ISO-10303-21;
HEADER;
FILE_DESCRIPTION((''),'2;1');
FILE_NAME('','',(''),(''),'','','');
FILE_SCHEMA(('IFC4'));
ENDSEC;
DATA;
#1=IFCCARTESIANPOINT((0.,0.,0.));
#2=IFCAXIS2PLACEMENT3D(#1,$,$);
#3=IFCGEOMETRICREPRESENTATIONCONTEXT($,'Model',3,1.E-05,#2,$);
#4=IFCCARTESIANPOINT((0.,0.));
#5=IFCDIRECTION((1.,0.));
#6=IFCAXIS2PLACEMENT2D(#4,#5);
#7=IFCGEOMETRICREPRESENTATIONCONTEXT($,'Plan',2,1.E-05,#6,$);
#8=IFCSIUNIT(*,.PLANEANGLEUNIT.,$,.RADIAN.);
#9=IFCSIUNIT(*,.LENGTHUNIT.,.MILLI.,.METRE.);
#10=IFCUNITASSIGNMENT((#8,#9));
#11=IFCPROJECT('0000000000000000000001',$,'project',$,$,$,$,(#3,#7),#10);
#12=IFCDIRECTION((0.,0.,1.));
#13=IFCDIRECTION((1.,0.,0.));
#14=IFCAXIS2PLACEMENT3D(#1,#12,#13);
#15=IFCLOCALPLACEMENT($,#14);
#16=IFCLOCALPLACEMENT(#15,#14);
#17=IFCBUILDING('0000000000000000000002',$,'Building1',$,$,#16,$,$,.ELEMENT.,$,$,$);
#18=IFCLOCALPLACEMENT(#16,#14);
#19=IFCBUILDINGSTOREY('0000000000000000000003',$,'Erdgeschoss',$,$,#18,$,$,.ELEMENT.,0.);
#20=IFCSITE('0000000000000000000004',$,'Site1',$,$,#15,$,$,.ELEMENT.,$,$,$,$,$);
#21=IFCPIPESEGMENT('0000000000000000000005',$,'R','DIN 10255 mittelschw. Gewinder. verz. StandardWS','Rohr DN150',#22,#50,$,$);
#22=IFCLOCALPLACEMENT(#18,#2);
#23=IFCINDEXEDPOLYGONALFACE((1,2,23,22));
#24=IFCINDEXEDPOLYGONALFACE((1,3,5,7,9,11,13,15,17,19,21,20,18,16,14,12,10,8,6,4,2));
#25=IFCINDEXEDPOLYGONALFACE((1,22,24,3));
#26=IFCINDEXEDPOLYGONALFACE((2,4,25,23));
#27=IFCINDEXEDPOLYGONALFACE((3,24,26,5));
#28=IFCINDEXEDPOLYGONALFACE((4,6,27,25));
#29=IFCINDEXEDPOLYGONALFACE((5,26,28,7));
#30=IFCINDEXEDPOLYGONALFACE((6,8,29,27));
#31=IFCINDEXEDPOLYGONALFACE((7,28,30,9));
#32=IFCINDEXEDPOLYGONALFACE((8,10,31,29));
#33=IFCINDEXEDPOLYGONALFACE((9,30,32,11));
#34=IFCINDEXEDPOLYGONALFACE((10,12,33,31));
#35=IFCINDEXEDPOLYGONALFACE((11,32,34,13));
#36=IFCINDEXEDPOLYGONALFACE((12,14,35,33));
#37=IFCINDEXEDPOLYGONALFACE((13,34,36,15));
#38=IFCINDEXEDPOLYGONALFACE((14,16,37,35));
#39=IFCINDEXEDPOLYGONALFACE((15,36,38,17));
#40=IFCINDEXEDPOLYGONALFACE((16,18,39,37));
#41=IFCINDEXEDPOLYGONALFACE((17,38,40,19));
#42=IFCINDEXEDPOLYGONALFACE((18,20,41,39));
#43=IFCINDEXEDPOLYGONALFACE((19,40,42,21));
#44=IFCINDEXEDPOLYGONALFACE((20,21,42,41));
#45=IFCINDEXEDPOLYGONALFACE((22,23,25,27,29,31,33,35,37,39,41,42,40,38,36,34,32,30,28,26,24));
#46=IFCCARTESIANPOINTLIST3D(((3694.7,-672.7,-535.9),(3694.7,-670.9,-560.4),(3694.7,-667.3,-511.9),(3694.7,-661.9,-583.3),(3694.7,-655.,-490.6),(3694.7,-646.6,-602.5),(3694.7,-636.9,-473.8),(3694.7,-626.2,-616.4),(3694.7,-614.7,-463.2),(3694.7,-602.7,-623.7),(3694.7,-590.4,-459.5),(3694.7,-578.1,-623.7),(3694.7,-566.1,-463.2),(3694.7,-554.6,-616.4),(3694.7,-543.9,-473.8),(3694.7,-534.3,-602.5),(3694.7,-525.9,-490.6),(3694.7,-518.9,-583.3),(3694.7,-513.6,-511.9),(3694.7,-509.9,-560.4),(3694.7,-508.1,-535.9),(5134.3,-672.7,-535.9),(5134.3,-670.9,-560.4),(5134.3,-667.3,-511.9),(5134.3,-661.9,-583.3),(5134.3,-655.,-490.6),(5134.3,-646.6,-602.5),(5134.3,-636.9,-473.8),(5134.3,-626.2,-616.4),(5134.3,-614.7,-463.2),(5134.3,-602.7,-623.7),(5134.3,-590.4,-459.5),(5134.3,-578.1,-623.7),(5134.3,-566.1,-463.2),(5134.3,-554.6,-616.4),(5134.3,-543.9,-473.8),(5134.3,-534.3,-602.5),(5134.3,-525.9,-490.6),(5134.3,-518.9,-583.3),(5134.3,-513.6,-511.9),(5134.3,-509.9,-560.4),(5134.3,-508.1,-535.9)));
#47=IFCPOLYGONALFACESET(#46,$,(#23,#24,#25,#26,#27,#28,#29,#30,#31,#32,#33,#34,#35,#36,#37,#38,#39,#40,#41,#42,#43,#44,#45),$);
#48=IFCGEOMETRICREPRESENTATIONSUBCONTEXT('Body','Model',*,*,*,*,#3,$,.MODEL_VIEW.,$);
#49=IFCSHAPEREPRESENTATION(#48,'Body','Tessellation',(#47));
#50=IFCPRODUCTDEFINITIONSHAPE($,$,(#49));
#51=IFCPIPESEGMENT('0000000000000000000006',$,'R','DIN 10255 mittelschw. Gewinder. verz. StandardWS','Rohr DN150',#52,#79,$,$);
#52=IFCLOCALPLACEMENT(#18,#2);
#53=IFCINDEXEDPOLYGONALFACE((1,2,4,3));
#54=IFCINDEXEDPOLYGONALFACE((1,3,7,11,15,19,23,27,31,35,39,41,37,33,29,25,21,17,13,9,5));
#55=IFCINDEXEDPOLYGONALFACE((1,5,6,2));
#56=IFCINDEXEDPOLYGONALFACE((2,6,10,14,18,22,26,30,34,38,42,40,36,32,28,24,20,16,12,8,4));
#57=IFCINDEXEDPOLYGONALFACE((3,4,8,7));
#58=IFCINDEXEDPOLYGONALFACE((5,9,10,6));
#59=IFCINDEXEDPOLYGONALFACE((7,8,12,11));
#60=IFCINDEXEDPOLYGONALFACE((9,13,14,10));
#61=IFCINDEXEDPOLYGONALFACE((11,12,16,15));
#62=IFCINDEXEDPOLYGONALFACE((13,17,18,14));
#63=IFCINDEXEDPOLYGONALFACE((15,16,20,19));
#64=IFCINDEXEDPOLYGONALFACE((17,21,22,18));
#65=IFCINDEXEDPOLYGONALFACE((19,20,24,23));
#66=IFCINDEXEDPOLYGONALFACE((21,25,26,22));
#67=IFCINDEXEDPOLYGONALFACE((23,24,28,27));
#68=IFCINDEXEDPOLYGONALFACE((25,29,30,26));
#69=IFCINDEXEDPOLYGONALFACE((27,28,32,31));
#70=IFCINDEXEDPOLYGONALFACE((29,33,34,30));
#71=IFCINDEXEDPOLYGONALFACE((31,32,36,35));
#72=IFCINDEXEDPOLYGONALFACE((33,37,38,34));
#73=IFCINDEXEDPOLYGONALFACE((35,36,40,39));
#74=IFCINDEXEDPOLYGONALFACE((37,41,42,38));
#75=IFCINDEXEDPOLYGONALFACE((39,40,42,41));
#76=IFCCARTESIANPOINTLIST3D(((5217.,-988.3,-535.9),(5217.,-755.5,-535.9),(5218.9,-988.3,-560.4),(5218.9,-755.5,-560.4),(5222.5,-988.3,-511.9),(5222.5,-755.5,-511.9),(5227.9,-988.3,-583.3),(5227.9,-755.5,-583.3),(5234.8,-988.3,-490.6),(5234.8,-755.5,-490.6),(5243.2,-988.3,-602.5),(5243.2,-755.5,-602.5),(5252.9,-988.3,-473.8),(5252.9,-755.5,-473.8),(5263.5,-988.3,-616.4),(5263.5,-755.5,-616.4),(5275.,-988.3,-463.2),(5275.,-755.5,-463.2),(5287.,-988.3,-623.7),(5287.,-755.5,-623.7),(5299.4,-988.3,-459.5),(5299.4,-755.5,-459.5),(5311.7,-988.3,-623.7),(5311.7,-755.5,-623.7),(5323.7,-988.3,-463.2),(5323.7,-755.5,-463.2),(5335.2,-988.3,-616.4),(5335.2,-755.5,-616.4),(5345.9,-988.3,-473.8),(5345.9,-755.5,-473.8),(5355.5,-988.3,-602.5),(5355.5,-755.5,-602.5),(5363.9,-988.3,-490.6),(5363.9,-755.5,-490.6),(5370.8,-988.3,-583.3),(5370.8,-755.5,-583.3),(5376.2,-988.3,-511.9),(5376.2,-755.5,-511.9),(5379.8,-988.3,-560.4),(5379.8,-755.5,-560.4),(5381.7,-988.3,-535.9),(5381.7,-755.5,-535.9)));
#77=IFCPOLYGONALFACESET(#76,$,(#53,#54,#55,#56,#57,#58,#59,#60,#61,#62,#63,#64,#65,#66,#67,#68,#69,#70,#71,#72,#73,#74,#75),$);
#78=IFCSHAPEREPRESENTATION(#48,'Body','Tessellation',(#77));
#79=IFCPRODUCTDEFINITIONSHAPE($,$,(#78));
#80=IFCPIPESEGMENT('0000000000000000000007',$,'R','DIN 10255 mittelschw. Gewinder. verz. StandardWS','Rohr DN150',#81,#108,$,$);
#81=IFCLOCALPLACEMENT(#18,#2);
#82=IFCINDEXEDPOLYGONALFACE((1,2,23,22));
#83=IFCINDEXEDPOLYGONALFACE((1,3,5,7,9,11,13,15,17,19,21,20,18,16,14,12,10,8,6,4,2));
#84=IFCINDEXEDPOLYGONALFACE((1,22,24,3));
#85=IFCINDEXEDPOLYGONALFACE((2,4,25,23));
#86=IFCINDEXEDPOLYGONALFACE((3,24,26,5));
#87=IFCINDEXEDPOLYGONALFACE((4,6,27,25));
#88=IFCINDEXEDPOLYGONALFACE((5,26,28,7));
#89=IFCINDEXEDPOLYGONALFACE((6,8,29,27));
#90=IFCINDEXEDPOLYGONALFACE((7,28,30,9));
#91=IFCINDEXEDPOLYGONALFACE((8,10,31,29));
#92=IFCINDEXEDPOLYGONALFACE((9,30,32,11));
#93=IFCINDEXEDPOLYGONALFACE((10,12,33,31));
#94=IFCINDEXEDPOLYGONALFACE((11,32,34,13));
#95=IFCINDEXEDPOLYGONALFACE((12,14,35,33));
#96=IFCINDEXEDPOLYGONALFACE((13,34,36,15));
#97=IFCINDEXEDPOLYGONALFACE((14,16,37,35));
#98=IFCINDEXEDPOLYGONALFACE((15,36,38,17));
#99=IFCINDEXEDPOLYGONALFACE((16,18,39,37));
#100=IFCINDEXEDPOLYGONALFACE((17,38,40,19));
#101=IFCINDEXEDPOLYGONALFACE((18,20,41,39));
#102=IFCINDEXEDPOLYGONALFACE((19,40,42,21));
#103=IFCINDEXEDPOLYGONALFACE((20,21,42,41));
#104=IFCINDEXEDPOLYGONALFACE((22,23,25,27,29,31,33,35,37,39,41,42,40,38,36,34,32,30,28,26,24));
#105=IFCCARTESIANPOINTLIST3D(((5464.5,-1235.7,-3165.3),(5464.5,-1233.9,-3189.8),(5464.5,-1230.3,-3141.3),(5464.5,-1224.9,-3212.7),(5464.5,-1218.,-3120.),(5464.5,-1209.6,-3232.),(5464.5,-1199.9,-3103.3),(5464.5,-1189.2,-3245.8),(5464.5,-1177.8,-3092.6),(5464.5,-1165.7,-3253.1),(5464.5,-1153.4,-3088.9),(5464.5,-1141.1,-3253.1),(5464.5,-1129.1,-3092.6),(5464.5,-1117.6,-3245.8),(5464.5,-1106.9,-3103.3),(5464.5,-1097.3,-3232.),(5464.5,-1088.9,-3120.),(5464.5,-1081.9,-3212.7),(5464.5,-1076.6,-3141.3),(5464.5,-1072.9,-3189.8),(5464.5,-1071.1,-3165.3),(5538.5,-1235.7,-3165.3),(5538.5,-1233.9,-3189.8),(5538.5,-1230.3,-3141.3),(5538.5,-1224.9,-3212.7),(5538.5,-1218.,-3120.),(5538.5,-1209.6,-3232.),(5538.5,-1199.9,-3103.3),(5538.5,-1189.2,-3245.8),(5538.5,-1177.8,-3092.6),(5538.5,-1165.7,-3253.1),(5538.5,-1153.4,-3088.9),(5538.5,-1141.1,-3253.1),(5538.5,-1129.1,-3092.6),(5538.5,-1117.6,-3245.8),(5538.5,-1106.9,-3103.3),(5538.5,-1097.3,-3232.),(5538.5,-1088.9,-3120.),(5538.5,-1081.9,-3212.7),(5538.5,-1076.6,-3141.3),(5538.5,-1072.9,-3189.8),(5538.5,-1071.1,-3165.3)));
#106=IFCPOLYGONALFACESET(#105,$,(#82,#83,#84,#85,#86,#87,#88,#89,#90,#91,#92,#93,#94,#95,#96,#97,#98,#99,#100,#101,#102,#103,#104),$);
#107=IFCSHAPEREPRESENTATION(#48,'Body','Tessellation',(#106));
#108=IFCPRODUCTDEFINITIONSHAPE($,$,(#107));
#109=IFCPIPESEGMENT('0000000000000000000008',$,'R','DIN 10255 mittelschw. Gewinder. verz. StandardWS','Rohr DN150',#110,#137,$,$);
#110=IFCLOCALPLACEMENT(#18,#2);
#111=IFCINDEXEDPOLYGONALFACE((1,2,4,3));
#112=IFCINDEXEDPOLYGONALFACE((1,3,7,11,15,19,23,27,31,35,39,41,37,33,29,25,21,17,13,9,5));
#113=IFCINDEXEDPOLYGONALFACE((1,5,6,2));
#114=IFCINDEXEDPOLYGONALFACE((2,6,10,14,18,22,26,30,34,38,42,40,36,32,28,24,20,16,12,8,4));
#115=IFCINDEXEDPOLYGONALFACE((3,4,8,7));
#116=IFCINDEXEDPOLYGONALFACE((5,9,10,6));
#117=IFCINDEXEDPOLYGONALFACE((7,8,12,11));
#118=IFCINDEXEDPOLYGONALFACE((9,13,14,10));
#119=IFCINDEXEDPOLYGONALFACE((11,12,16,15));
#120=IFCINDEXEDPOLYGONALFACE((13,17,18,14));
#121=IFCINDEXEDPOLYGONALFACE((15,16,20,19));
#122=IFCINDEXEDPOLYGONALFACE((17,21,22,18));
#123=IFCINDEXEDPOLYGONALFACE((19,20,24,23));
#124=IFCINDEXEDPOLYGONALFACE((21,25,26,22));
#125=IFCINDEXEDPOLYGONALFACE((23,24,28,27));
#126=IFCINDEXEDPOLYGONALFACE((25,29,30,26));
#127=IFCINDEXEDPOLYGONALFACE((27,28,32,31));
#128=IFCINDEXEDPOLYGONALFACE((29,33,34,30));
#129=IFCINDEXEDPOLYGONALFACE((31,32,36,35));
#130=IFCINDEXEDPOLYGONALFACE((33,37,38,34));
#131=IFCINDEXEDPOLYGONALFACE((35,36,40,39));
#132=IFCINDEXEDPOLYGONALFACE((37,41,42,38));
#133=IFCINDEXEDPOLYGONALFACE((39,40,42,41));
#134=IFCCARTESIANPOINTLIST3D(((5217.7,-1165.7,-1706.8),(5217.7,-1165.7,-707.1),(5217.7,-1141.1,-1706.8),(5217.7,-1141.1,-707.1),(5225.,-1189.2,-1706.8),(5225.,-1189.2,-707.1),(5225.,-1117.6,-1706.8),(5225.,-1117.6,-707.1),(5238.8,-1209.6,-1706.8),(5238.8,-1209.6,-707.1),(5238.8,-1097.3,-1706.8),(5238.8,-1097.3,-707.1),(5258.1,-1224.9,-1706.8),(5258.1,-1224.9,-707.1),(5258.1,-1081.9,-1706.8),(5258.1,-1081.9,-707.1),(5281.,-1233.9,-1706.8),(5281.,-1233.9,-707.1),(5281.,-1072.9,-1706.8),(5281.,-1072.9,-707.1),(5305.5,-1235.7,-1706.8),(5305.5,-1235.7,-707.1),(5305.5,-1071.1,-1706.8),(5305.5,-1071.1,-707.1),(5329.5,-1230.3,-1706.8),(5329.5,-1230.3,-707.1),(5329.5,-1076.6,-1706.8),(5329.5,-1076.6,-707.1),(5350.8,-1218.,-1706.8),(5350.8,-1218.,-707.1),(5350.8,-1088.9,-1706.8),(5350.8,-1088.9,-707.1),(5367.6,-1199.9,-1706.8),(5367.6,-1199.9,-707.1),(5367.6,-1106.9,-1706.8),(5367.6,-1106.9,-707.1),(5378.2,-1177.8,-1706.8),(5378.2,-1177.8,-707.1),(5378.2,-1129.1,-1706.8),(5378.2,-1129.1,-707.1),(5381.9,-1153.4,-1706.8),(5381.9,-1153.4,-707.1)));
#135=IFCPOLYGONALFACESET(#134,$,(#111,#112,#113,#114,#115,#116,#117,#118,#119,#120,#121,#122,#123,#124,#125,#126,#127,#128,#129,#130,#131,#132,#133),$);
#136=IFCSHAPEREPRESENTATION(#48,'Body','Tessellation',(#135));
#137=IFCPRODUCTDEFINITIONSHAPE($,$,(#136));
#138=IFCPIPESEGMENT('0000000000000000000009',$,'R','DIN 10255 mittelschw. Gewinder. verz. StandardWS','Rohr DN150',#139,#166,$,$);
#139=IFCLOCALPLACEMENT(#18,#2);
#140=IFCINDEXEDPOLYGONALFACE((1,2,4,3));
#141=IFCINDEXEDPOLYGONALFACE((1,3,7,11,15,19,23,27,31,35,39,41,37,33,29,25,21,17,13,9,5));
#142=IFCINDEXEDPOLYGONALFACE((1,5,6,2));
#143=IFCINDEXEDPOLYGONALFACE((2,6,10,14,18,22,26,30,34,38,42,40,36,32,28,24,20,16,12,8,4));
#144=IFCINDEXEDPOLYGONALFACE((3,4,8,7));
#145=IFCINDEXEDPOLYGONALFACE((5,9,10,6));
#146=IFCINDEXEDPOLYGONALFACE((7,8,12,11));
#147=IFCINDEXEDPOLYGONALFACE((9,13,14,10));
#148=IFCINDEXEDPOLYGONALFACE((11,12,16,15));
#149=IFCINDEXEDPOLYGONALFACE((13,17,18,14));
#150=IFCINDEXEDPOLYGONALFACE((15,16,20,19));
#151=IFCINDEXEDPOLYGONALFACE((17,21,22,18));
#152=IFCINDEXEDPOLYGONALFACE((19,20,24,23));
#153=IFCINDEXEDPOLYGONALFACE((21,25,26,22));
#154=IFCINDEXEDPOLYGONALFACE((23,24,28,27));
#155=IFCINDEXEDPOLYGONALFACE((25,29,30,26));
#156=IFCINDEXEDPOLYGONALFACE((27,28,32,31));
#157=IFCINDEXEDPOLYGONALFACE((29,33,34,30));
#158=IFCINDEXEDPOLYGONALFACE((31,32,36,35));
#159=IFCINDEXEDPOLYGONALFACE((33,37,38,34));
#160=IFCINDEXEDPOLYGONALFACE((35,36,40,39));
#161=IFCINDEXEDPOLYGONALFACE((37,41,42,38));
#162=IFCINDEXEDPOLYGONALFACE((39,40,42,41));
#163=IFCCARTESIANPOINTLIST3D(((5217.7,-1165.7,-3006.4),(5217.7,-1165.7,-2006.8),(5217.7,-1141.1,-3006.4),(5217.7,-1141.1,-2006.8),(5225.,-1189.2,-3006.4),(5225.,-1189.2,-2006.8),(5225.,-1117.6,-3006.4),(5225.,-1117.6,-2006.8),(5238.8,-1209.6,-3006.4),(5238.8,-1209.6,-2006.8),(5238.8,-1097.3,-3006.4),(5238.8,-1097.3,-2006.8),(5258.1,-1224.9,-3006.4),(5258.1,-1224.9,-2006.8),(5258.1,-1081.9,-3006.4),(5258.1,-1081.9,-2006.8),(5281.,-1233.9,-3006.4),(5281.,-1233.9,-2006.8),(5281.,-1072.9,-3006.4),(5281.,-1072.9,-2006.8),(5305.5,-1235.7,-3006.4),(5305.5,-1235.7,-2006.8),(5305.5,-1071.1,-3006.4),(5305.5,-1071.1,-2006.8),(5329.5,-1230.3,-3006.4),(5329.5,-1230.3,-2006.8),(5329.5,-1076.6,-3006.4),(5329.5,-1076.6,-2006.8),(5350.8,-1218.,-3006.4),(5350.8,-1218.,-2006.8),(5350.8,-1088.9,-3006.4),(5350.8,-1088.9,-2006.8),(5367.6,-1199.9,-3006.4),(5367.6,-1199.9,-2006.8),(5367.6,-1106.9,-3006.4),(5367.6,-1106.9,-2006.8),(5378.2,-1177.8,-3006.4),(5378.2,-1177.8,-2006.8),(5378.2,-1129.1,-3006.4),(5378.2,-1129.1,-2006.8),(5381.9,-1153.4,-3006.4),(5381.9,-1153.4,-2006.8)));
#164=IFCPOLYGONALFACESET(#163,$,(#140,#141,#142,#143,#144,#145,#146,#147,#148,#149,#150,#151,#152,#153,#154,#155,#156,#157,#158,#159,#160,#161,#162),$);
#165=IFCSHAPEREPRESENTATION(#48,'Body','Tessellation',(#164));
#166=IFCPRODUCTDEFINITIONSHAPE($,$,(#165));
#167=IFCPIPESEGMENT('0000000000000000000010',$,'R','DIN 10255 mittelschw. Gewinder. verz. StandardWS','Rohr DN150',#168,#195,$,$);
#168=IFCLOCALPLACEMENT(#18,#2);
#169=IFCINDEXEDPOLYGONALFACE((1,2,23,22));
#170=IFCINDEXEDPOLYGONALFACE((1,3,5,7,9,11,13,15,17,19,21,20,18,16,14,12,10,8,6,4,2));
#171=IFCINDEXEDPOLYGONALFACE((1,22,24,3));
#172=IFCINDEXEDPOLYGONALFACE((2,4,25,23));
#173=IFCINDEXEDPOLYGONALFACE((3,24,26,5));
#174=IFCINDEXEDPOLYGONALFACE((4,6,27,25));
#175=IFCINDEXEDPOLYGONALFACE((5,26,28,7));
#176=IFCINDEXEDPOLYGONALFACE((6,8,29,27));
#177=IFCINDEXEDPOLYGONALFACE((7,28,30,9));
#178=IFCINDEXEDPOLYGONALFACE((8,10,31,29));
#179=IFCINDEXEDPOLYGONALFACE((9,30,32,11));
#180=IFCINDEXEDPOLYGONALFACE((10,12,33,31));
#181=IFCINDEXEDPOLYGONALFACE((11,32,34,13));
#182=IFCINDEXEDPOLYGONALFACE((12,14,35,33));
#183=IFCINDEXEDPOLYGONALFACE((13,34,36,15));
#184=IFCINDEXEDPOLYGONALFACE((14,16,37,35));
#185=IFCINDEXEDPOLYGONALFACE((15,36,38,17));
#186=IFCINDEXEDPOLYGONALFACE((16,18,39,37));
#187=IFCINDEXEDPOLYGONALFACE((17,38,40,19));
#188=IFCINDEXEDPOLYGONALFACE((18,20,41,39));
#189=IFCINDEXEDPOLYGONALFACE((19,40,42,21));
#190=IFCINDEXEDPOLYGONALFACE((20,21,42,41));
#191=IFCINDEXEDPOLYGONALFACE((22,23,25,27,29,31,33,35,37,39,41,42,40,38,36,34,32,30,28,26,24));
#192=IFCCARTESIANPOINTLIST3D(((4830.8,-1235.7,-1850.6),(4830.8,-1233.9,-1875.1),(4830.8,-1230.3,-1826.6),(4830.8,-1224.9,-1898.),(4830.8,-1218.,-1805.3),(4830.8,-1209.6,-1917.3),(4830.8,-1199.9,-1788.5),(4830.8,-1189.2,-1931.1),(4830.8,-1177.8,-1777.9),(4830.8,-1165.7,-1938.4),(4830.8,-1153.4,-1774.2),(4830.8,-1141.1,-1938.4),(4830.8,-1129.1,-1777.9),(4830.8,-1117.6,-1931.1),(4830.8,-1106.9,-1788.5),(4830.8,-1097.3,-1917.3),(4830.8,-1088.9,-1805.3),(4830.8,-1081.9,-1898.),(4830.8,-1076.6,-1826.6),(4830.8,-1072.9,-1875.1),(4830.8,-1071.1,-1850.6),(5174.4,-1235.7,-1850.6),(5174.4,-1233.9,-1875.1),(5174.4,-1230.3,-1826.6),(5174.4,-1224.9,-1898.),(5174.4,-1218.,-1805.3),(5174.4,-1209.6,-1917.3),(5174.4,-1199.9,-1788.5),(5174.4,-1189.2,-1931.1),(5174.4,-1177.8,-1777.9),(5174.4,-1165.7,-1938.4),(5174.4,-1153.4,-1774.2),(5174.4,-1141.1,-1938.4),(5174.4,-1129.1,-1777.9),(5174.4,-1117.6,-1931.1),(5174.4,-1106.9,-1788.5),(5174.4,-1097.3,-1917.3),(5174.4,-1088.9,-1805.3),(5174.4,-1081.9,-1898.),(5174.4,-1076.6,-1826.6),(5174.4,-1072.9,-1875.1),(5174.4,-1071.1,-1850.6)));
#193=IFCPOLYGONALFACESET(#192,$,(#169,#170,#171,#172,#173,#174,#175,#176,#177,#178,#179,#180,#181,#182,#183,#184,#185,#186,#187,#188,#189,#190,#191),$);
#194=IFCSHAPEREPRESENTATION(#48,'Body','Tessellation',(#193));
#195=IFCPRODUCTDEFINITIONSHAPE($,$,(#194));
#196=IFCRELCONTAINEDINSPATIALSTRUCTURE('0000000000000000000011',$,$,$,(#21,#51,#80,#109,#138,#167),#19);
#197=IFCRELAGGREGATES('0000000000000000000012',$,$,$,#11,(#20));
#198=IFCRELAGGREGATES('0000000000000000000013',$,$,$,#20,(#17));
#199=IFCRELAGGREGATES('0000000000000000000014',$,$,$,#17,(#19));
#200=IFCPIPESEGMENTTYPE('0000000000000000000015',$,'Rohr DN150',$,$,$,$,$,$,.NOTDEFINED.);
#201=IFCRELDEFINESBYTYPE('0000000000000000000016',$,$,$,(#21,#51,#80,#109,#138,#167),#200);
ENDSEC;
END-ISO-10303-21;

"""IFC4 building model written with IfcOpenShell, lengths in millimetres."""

from ifc_helpers import new_model, si_unit, frame, origin, origin_with_axes, origin_2d_with_axis, place, context, subcontext, project, spatial, circle, extrude, type_object, element, save


model = new_model("IFC4")

# Units and contexts
model_context = context("Model", 3, precision=1e-05, world=origin())
plan_context = context("Plan", 2, precision=1e-05, world=origin_2d_with_axis())
body_context = subcontext(model_context, "Body", "Model", "MODEL_VIEW")
ifc_project = project(units=[si_unit("PLANEANGLEUNIT", "RADIAN"), si_unit("LENGTHUNIT", "METRE", prefix="MILLI")], contexts=[model_context, plan_context])

# Site, building, storey
site_placement = place(None, origin_with_axes())
site = spatial("IfcSite", under=ifc_project, at=site_placement, Name="Site1", CompositionType="ELEMENT")
building_placement = place(site_placement, origin_with_axes())
building = spatial("IfcBuilding", under=site, at=building_placement, Name="Building1", CompositionType="ELEMENT")
storey_placement = place(building_placement, origin_with_axes())
storey = spatial("IfcBuildingStorey", under=building, at=storey_placement, Name="Erdgeschoss", CompositionType="ELEMENT", Elevation=0.0)

# Pipe segments
pipe_segment_type_1 = type_object("IfcPipeSegmentType", Name="Rohr DN150", PredefinedType="NOTDEFINED")
pipe_segment_1_placement = place(storey_placement, frame((4414.5, -590.3, -542.0), z_axis=(0.0, 0.0, 1.0), x_axis=(1.0, 0.0, 0.0)))
element("IfcPipeSegment", 1, at=pipe_segment_1_placement, inside=storey, type_object=pipe_segment_type_1, Name="R", Description="DIN 10255 mittelschw. Gewinder. verz. StandardWS", ObjectType="Rohr DN150", context=body_context, shape_type="SolidModel", body=[
    extrude(circle(Radius=82.5, at=origin_2d_with_axis()), frame((-719.8, -0.2, 0.0), z_axis=(1.0, 0.0, 0.0), x_axis=(0.0, 0.0, 1.0)), (0.0, 0.0, 1.0), 1439.6),
])
pipe_segment_2_placement = place(storey_placement, frame((5299.5, -871.9, -542.0), z_axis=(0.0, 0.0, 1.0), x_axis=(1.0, 0.0, 0.0)))
element("IfcPipeSegment", 2, at=pipe_segment_2_placement, inside=storey, type_object=pipe_segment_type_1, Name="R", Description="DIN 10255 mittelschw. Gewinder. verz. StandardWS", ObjectType="Rohr DN150", context=body_context, shape_type="SolidModel", body=[
    extrude(circle(Radius=82.5, at=origin_2d_with_axis()), frame((-0.2, 116.4, 0.0), z_axis=(0.0, -1.0, 0.0), x_axis=(0.0, 0.0, 1.0)), (0.0, 0.0, 1.0), 232.8),
])
pipe_segment_3_placement = place(storey_placement, frame((5501.5, -1153.6, -3171.5), z_axis=(0.0, 0.0, 1.0), x_axis=(1.0, 0.0, 0.0)))
element("IfcPipeSegment", 3, at=pipe_segment_3_placement, inside=storey, type_object=pipe_segment_type_1, Name="R", Description="DIN 10255 mittelschw. Gewinder. verz. StandardWS", ObjectType="Rohr DN150", context=body_context, shape_type="SolidModel", body=[
    extrude(circle(Radius=82.5, at=origin_2d_with_axis()), frame((37.0, 0.1, 0.0), z_axis=(-1.0, 0.0, 0.0), x_axis=(0.0, 0.0, 1.0)), (0.0, 0.0, 1.0), 74.0),
])
for number, where, z_axis, x_axis, name in (
    (4, (5299.4, -1153.3, -1206.9), (0.0, 0.0, 1.0), (1.0, 0.0, 0.0), "R"),
    (5, (5299.4, -1153.3, -2506.6), (0.0, 0.0, 1.0), (1.0, 0.0, 0.0), "R"),
):
    element("IfcPipeSegment", number, at=place(storey_placement, frame(where, z_axis=z_axis, x_axis=x_axis)), inside=storey, type_object=pipe_segment_type_1, Name=name, Description="DIN 10255 mittelschw. Gewinder. verz. StandardWS", ObjectType="Rohr DN150", context=body_context, shape_type="SolidModel", body=[
        extrude(circle(Radius=82.5, at=origin_2d_with_axis()), frame((0.0, -0.1, 499.8), z_axis=(0.0, 0.0, -1.0), x_axis=(1.0, 0.0, 0.0)), (0.0, 0.0, 1.0), 999.6),
    ])
pipe_segment_4_placement = place(storey_placement, frame((5002.6, -1153.6, -1856.8), z_axis=(0.0, 0.0, 1.0), x_axis=(1.0, 0.0, 0.0)))
element("IfcPipeSegment", 6, at=pipe_segment_4_placement, inside=storey, type_object=pipe_segment_type_1, Name="R", Description="DIN 10255 mittelschw. Gewinder. verz. StandardWS", ObjectType="Rohr DN150", context=body_context, shape_type="SolidModel", body=[
    extrude(circle(Radius=82.5, at=origin_2d_with_axis()), frame((171.8, 0.2, 0.0), z_axis=(-1.0, 0.0, 0.0), x_axis=(0.0, 0.0, 1.0)), (0.0, 0.0, 1.0), 343.6),
])

save(model, "model.ifc")
